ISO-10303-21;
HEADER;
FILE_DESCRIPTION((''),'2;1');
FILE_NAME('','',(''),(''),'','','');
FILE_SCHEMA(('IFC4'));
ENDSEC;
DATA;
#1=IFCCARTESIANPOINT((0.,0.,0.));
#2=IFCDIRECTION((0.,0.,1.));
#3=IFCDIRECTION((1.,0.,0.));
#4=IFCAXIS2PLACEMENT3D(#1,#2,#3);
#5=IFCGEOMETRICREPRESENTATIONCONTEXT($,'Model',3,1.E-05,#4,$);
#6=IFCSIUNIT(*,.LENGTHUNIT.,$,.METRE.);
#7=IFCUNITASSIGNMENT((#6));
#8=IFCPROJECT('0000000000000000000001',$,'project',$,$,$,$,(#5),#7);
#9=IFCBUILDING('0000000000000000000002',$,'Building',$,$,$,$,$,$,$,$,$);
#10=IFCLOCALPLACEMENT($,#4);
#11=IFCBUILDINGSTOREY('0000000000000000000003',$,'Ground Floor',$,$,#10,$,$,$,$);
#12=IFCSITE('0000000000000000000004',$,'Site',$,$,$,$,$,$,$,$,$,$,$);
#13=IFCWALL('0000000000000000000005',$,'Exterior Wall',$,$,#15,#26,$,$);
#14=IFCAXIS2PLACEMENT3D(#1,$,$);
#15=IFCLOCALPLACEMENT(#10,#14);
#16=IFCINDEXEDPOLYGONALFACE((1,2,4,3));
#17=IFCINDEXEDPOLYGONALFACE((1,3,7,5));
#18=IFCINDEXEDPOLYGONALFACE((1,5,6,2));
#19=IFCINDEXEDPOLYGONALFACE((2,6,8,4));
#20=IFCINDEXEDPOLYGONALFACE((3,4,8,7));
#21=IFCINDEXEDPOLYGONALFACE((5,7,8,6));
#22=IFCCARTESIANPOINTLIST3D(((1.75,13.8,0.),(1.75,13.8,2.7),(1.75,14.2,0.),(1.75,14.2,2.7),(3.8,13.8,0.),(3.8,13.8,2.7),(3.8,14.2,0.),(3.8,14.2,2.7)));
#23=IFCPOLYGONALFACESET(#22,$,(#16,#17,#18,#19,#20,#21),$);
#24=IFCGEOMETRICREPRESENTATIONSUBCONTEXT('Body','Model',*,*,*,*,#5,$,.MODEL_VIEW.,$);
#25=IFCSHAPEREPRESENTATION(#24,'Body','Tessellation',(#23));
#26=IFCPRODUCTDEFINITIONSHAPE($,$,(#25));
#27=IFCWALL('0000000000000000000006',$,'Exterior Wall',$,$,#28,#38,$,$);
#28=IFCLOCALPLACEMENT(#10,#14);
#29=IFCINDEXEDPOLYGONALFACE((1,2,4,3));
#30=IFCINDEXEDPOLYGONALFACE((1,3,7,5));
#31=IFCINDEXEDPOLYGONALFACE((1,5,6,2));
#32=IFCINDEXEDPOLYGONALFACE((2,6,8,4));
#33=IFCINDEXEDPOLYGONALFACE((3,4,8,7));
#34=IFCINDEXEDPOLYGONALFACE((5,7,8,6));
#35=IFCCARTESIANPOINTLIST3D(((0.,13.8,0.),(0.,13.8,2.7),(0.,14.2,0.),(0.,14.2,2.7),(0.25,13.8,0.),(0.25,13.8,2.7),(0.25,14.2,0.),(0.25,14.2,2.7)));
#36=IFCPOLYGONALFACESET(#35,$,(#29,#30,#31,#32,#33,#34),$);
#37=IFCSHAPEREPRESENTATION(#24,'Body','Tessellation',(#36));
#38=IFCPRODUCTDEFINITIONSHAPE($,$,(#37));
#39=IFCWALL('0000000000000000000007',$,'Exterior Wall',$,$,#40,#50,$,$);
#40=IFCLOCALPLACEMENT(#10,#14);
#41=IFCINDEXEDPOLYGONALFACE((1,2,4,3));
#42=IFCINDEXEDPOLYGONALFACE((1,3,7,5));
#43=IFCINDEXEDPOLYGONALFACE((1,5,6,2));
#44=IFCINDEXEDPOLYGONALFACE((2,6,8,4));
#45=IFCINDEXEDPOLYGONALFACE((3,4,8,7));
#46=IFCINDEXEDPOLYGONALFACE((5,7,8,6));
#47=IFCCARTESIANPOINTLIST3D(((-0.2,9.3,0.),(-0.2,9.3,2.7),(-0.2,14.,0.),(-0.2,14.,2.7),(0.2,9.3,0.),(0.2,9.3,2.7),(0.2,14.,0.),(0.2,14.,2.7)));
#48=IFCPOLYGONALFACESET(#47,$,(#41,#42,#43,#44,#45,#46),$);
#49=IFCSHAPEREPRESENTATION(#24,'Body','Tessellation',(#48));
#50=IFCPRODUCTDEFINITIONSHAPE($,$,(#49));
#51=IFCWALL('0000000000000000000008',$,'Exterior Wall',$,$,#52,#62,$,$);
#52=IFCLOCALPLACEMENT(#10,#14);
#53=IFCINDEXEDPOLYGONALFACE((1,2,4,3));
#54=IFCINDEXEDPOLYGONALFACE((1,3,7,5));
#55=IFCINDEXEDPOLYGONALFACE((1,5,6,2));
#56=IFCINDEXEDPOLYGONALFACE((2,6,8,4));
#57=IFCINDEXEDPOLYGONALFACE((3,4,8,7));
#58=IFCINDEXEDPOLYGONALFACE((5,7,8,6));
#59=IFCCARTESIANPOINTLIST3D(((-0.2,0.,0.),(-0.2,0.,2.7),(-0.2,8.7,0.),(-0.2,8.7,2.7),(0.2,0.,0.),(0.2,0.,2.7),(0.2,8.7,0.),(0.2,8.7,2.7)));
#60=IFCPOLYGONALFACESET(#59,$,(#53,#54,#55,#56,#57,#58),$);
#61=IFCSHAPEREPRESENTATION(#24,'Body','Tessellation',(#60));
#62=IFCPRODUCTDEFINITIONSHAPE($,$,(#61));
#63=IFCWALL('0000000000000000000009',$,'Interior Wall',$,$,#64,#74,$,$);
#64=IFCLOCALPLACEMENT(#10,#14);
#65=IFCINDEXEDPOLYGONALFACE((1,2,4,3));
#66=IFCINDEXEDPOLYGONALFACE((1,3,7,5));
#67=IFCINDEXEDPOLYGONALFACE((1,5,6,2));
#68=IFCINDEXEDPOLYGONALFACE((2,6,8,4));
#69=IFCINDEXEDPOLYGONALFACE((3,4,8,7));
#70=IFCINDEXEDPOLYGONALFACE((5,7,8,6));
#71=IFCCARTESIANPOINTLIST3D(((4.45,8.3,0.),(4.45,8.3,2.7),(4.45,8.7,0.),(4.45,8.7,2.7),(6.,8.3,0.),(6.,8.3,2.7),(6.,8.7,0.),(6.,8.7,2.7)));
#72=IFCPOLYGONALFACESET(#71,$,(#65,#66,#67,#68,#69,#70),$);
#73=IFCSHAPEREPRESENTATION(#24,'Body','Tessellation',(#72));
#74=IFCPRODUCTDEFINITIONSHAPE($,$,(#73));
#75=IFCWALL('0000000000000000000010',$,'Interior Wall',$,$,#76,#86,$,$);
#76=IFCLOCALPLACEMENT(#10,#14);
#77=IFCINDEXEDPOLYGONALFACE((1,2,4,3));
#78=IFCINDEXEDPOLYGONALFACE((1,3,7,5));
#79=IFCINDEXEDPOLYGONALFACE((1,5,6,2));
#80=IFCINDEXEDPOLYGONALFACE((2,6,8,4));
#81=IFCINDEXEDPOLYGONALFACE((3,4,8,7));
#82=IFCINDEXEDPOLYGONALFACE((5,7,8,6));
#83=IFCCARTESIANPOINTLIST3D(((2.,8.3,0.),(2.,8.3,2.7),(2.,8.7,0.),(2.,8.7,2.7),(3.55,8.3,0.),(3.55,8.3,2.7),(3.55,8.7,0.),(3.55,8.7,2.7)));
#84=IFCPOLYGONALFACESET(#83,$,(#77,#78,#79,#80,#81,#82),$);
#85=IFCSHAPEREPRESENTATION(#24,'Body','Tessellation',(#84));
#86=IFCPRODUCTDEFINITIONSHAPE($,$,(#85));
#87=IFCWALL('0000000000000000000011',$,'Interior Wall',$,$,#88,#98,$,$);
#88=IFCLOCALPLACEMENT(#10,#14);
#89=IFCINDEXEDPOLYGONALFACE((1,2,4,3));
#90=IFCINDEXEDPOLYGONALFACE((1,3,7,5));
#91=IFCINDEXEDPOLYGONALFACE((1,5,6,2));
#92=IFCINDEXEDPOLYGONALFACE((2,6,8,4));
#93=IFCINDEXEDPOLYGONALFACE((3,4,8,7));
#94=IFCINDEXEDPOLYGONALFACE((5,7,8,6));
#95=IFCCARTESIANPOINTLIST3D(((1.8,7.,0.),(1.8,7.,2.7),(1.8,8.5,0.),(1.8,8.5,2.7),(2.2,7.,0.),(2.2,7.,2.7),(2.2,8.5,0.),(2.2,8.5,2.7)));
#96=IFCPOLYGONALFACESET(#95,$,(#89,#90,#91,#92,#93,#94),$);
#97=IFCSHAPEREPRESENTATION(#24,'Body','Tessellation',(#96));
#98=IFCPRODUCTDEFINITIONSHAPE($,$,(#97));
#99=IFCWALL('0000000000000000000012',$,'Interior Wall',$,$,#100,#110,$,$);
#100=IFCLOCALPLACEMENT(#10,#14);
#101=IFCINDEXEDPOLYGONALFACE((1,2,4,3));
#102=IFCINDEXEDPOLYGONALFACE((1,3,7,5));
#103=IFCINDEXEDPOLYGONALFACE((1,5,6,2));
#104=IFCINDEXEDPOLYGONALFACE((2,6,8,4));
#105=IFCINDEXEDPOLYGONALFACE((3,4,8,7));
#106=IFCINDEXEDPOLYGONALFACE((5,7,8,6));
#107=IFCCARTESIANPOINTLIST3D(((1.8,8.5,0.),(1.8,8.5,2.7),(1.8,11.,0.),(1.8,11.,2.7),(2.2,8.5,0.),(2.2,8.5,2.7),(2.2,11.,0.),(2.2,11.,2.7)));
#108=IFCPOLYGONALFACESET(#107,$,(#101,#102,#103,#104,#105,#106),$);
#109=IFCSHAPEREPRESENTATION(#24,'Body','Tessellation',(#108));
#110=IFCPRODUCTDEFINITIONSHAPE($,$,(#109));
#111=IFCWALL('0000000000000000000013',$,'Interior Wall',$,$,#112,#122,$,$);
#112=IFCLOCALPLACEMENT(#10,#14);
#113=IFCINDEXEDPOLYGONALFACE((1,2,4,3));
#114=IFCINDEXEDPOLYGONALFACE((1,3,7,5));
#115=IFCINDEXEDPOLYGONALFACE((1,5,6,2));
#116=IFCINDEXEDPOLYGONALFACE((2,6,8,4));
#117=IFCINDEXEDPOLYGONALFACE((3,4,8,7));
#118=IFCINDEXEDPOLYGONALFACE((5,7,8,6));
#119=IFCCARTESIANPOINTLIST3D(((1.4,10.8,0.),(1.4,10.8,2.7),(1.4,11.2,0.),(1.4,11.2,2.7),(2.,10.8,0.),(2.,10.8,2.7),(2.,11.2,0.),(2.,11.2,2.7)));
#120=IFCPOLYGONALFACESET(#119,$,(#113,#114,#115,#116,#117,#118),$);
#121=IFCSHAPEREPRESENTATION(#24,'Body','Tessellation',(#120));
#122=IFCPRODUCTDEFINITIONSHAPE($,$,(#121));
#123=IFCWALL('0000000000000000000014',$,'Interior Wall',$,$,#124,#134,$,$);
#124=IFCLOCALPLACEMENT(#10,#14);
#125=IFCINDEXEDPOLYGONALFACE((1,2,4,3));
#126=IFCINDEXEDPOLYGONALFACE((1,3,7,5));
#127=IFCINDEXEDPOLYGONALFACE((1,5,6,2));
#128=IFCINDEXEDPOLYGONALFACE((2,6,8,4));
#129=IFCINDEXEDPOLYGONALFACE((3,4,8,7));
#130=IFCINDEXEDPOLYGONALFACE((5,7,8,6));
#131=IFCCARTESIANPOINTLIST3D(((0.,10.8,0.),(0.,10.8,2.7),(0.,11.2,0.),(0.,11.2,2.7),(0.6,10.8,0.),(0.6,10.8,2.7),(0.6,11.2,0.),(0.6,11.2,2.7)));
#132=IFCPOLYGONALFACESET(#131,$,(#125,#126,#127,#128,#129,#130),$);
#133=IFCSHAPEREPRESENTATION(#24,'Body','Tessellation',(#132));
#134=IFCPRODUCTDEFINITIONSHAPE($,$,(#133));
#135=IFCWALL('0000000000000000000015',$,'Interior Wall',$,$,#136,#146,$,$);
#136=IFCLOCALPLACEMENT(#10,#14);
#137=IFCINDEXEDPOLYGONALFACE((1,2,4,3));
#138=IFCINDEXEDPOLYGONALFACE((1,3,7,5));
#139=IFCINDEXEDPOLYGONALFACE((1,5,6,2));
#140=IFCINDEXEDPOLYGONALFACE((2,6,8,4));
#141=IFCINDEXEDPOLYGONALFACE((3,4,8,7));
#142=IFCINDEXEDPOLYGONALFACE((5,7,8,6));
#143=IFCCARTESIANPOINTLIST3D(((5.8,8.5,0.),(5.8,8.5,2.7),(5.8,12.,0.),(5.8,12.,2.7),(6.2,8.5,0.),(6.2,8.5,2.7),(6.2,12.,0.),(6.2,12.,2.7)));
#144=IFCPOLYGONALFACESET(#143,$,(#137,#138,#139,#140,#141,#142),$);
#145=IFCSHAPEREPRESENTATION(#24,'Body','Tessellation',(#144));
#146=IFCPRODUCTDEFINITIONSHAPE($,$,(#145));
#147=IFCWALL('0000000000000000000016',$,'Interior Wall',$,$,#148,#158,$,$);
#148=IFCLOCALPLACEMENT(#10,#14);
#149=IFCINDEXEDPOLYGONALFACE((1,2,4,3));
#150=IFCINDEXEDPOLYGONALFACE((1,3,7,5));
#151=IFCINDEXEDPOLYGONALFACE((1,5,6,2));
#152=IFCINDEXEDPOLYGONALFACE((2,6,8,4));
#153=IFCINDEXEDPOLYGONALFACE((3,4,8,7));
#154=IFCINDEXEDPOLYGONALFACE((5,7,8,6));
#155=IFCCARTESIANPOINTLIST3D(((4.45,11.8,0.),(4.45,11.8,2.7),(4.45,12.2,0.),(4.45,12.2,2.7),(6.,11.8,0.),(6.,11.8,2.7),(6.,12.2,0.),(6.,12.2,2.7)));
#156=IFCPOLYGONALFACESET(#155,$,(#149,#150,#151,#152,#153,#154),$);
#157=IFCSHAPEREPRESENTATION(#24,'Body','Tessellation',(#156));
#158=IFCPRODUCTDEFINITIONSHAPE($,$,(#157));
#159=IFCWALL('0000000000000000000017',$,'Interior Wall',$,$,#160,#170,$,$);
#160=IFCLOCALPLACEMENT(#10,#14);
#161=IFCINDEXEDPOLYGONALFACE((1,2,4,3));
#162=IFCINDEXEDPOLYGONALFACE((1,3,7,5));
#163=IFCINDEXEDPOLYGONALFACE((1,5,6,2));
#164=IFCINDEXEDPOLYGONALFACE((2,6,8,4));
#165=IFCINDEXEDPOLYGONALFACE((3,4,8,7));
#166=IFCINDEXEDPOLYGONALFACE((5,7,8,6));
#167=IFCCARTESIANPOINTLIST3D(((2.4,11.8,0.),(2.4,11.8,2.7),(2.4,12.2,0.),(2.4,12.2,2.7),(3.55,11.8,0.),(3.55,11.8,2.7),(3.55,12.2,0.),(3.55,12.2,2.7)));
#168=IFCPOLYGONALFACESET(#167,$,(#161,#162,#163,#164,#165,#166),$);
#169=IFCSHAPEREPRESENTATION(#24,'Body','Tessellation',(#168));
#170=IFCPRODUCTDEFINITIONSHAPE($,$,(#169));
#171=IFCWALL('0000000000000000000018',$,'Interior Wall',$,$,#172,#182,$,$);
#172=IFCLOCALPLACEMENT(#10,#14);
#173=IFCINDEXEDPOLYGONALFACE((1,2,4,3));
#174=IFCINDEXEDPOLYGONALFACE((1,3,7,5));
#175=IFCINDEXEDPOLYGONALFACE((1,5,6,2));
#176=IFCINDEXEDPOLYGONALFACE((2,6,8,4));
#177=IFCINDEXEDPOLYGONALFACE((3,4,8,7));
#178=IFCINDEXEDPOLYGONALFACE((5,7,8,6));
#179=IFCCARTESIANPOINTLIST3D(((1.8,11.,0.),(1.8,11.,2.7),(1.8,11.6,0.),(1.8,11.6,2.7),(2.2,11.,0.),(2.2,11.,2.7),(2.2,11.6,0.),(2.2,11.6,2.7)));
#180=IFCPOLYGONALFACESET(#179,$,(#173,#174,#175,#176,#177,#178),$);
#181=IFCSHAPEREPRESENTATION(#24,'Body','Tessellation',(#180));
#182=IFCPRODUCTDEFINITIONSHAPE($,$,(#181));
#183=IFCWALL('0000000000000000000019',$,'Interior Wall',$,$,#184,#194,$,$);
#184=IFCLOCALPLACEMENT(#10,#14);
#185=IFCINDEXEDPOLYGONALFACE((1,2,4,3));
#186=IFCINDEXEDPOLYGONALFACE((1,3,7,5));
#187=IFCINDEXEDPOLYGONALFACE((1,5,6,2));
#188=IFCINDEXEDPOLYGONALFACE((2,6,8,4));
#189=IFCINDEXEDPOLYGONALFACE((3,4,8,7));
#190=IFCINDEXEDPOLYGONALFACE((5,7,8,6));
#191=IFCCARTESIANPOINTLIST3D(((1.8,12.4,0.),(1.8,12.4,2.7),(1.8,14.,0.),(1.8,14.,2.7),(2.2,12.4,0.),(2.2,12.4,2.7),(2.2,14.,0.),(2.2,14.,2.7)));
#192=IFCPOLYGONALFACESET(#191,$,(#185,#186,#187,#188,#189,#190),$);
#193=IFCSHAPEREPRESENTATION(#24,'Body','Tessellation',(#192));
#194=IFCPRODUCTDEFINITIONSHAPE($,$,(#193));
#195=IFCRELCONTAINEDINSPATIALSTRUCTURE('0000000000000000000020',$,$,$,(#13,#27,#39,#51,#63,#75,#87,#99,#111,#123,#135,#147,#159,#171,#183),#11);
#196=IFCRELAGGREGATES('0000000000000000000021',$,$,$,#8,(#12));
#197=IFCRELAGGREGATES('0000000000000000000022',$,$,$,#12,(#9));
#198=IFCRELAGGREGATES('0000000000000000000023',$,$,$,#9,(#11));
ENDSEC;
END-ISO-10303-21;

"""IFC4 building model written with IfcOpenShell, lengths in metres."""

from ifc_helpers import new_model, si_unit, frame, origin_with_axes, place, context, subcontext, project, spatial, indexed_curve, outline, extrude, element, save


model = new_model("IFC4")

# Units and contexts
model_context = context("Model", 3, precision=1e-05, world=origin_with_axes())
body_context = subcontext(model_context, "Body", "Model", "MODEL_VIEW")
ifc_project = project(units=[si_unit("LENGTHUNIT", "METRE")], contexts=[model_context])

# Site, building, storey
site = spatial("IfcSite", under=ifc_project, Name="Site")
building = spatial("IfcBuilding", under=site, Name="Building")
storey_placement = place(None, origin_with_axes())
storey = spatial("IfcBuildingStorey", under=building, at=storey_placement, Name="Ground Floor")

# Walls
wall_1_placement = place(storey_placement, frame((3.8, 14.0, 0.0), z_axis=(0.0, 0.0, 1.0), x_axis=(-1.0, 0.0, 0.0)))
element("IfcWall", 1, at=wall_1_placement, inside=storey, Name="Exterior Wall", context=body_context, shape_type="SweptSolid", body=[
    extrude(outline(indexed_curve([(0.0, 0.0), (0.0, 0.4), (2.05, 0.4), (2.05, 0.0), (0.0, 0.0)], self_intersect=False)), frame((0.0, -0.2, 0.0), z_axis=(0.0, 0.0, 1.0), x_axis=(1.0, 0.0, 0.0)), (0.0, 0.0, 1.0), 2.7),
])
wall_2_placement = place(storey_placement, frame((0.25, 14.0, 0.0), z_axis=(0.0, 0.0, 1.0), x_axis=(-1.0, 0.0, 0.0)))
element("IfcWall", 2, at=wall_2_placement, inside=storey, Name="Exterior Wall", context=body_context, shape_type="SweptSolid", body=[
    extrude(outline(indexed_curve([(0.0, 0.0), (0.0, 0.4), (0.25, 0.4), (0.25, 0.0), (0.0, 0.0)], self_intersect=False)), frame((0.0, -0.2, 0.0), z_axis=(0.0, 0.0, 1.0), x_axis=(1.0, 0.0, 0.0)), (0.0, 0.0, 1.0), 2.7),
])
wall_3_placement = place(storey_placement, frame((0.0, 14.0, 0.0), z_axis=(0.0, 0.0, 1.0), x_axis=(0.0, -1.0, 0.0)))
element("IfcWall", 3, at=wall_3_placement, inside=storey, Name="Exterior Wall", context=body_context, shape_type="SweptSolid", body=[
    extrude(outline(indexed_curve([(0.0, 0.0), (0.0, 0.4), (4.7, 0.4), (4.7, 0.0), (0.0, 0.0)], self_intersect=False)), frame((0.0, -0.2, 0.0), z_axis=(0.0, 0.0, 1.0), x_axis=(1.0, 0.0, 0.0)), (0.0, 0.0, 1.0), 2.7),
])
wall_4_placement = place(storey_placement, frame((0.0, 8.7, 0.0), z_axis=(0.0, 0.0, 1.0), x_axis=(0.0, -1.0, 0.0)))
element("IfcWall", 4, at=wall_4_placement, inside=storey, Name="Exterior Wall", context=body_context, shape_type="SweptSolid", body=[
    extrude(outline(indexed_curve([(0.0, 0.0), (0.0, 0.4), (8.7, 0.4), (8.7, 0.0), (0.0, 0.0)], self_intersect=False)), frame((0.0, -0.2, 0.0), z_axis=(0.0, 0.0, 1.0), x_axis=(1.0, 0.0, 0.0)), (0.0, 0.0, 1.0), 2.7),
])
for number, where, z_axis, x_axis, name in (
    (5, (6.0, 8.5, 0.0), (0.0, 0.0, 1.0), (-1.0, 0.0, 0.0), "Interior Wall"),
    (6, (3.55, 8.5, 0.0), (0.0, 0.0, 1.0), (-1.0, 0.0, 0.0), "Interior Wall"),
):
    element("IfcWall", number, at=place(storey_placement, frame(where, z_axis=z_axis, x_axis=x_axis)), inside=storey, Name=name, context=body_context, shape_type="SweptSolid", body=[
        extrude(outline(indexed_curve([(0.0, 0.0), (0.0, 0.4), (1.55, 0.4), (1.55, 0.0), (0.0, 0.0)], self_intersect=False)), frame((0.0, -0.2, 0.0), z_axis=(0.0, 0.0, 1.0), x_axis=(1.0, 0.0, 0.0)), (0.0, 0.0, 1.0), 2.7),
    ])
wall_5_placement = place(storey_placement, frame((2.0, 8.5, 0.0), z_axis=(0.0, 0.0, 1.0), x_axis=(0.0, -1.0, 0.0)))
element("IfcWall", 7, at=wall_5_placement, inside=storey, Name="Interior Wall", context=body_context, shape_type="SweptSolid", body=[
    extrude(outline(indexed_curve([(0.0, 0.0), (0.0, 0.4), (1.5, 0.4), (1.5, 0.0), (0.0, 0.0)], self_intersect=False)), frame((0.0, -0.2, 0.0), z_axis=(0.0, 0.0, 1.0), x_axis=(1.0, 0.0, 0.0)), (0.0, 0.0, 1.0), 2.7),
])
wall_6_placement = place(storey_placement, frame((2.0, 8.5, 0.0), z_axis=(0.0, 0.0, 1.0), x_axis=(0.0, 1.0, 0.0)))
element("IfcWall", 8, at=wall_6_placement, inside=storey, Name="Interior Wall", context=body_context, shape_type="SweptSolid", body=[
    extrude(outline(indexed_curve([(0.0, 0.0), (0.0, 0.4), (2.5, 0.4), (2.5, 0.0), (0.0, 0.0)], self_intersect=False)), frame((0.0, -0.2, 0.0), z_axis=(0.0, 0.0, 1.0), x_axis=(1.0, 0.0, 0.0)), (0.0, 0.0, 1.0), 2.7),
])
for number, where, z_axis, x_axis, name in (
    (9, (2.0, 11.0, 0.0), (0.0, 0.0, 1.0), (-1.0, 0.0, 0.0), "Interior Wall"),
    (10, (0.6, 11.0, 0.0), (0.0, 0.0, 1.0), (-1.0, 0.0, 0.0), "Interior Wall"),
):
    element("IfcWall", number, at=place(storey_placement, frame(where, z_axis=z_axis, x_axis=x_axis)), inside=storey, Name=name, context=body_context, shape_type="SweptSolid", body=[
        extrude(outline(indexed_curve([(0.0, 0.0), (0.0, 0.4), (0.6, 0.4), (0.6, 0.0), (0.0, 0.0)], self_intersect=False)), frame((0.0, -0.2, 0.0), z_axis=(0.0, 0.0, 1.0), x_axis=(1.0, 0.0, 0.0)), (0.0, 0.0, 1.0), 2.7),
    ])
wall_7_placement = place(storey_placement, frame((6.0, 8.5, 0.0), z_axis=(0.0, 0.0, 1.0), x_axis=(0.0, 1.0, 0.0)))
element("IfcWall", 11, at=wall_7_placement, inside=storey, Name="Interior Wall", context=body_context, shape_type="SweptSolid", body=[
    extrude(outline(indexed_curve([(0.0, 0.0), (0.0, 0.4), (3.5, 0.4), (3.5, 0.0), (0.0, 0.0)], self_intersect=False)), frame((0.0, -0.2, 0.0), z_axis=(0.0, 0.0, 1.0), x_axis=(1.0, 0.0, 0.0)), (0.0, 0.0, 1.0), 2.7),
])
wall_8_placement = place(storey_placement, frame((6.0, 12.0, 0.0), z_axis=(0.0, 0.0, 1.0), x_axis=(-1.0, 0.0, 0.0)))
element("IfcWall", 12, at=wall_8_placement, inside=storey, Name="Interior Wall", context=body_context, shape_type="SweptSolid", body=[
    extrude(outline(indexed_curve([(0.0, 0.0), (0.0, 0.4), (1.55, 0.4), (1.55, 0.0), (0.0, 0.0)], self_intersect=False)), frame((0.0, -0.2, 0.0), z_axis=(0.0, 0.0, 1.0), x_axis=(1.0, 0.0, 0.0)), (0.0, 0.0, 1.0), 2.7),
])
wall_9_placement = place(storey_placement, frame((3.55, 12.0, 0.0), z_axis=(0.0, 0.0, 1.0), x_axis=(-1.0, 0.0, 0.0)))
element("IfcWall", 13, at=wall_9_placement, inside=storey, Name="Interior Wall", context=body_context, shape_type="SweptSolid", body=[
    extrude(outline(indexed_curve([(0.0, 0.0), (0.0, 0.4), (1.15, 0.4), (1.15, 0.0), (0.0, 0.0)], self_intersect=False)), frame((0.0, -0.2, 0.0), z_axis=(0.0, 0.0, 1.0), x_axis=(1.0, 0.0, 0.0)), (0.0, 0.0, 1.0), 2.7),
])
wall_10_placement = place(storey_placement, frame((2.0, 11.6, 0.0), z_axis=(0.0, 0.0, 1.0), x_axis=(0.0, -1.0, 0.0)))
element("IfcWall", 14, at=wall_10_placement, inside=storey, Name="Interior Wall", context=body_context, shape_type="SweptSolid", body=[
    extrude(outline(indexed_curve([(0.0, 0.0), (0.0, 0.4), (0.6, 0.4), (0.6, 0.0), (0.0, 0.0)], self_intersect=False)), frame((0.0, -0.2, 0.0), z_axis=(0.0, 0.0, 1.0), x_axis=(1.0, 0.0, 0.0)), (0.0, 0.0, 1.0), 2.7),
])
wall_11_placement = place(storey_placement, frame((2.0, 14.0, 0.0), z_axis=(0.0, 0.0, 1.0), x_axis=(0.0, -1.0, 0.0)))
element("IfcWall", 15, at=wall_11_placement, inside=storey, Name="Interior Wall", context=body_context, shape_type="SweptSolid", body=[
    extrude(outline(indexed_curve([(0.0, 0.0), (0.0, 0.4), (1.6, 0.4), (1.6, 0.0), (0.0, 0.0)], self_intersect=False)), frame((0.0, -0.2, 0.0), z_axis=(0.0, 0.0, 1.0), x_axis=(1.0, 0.0, 0.0)), (0.0, 0.0, 1.0), 2.7),
])

save(model, "model.ifc")
